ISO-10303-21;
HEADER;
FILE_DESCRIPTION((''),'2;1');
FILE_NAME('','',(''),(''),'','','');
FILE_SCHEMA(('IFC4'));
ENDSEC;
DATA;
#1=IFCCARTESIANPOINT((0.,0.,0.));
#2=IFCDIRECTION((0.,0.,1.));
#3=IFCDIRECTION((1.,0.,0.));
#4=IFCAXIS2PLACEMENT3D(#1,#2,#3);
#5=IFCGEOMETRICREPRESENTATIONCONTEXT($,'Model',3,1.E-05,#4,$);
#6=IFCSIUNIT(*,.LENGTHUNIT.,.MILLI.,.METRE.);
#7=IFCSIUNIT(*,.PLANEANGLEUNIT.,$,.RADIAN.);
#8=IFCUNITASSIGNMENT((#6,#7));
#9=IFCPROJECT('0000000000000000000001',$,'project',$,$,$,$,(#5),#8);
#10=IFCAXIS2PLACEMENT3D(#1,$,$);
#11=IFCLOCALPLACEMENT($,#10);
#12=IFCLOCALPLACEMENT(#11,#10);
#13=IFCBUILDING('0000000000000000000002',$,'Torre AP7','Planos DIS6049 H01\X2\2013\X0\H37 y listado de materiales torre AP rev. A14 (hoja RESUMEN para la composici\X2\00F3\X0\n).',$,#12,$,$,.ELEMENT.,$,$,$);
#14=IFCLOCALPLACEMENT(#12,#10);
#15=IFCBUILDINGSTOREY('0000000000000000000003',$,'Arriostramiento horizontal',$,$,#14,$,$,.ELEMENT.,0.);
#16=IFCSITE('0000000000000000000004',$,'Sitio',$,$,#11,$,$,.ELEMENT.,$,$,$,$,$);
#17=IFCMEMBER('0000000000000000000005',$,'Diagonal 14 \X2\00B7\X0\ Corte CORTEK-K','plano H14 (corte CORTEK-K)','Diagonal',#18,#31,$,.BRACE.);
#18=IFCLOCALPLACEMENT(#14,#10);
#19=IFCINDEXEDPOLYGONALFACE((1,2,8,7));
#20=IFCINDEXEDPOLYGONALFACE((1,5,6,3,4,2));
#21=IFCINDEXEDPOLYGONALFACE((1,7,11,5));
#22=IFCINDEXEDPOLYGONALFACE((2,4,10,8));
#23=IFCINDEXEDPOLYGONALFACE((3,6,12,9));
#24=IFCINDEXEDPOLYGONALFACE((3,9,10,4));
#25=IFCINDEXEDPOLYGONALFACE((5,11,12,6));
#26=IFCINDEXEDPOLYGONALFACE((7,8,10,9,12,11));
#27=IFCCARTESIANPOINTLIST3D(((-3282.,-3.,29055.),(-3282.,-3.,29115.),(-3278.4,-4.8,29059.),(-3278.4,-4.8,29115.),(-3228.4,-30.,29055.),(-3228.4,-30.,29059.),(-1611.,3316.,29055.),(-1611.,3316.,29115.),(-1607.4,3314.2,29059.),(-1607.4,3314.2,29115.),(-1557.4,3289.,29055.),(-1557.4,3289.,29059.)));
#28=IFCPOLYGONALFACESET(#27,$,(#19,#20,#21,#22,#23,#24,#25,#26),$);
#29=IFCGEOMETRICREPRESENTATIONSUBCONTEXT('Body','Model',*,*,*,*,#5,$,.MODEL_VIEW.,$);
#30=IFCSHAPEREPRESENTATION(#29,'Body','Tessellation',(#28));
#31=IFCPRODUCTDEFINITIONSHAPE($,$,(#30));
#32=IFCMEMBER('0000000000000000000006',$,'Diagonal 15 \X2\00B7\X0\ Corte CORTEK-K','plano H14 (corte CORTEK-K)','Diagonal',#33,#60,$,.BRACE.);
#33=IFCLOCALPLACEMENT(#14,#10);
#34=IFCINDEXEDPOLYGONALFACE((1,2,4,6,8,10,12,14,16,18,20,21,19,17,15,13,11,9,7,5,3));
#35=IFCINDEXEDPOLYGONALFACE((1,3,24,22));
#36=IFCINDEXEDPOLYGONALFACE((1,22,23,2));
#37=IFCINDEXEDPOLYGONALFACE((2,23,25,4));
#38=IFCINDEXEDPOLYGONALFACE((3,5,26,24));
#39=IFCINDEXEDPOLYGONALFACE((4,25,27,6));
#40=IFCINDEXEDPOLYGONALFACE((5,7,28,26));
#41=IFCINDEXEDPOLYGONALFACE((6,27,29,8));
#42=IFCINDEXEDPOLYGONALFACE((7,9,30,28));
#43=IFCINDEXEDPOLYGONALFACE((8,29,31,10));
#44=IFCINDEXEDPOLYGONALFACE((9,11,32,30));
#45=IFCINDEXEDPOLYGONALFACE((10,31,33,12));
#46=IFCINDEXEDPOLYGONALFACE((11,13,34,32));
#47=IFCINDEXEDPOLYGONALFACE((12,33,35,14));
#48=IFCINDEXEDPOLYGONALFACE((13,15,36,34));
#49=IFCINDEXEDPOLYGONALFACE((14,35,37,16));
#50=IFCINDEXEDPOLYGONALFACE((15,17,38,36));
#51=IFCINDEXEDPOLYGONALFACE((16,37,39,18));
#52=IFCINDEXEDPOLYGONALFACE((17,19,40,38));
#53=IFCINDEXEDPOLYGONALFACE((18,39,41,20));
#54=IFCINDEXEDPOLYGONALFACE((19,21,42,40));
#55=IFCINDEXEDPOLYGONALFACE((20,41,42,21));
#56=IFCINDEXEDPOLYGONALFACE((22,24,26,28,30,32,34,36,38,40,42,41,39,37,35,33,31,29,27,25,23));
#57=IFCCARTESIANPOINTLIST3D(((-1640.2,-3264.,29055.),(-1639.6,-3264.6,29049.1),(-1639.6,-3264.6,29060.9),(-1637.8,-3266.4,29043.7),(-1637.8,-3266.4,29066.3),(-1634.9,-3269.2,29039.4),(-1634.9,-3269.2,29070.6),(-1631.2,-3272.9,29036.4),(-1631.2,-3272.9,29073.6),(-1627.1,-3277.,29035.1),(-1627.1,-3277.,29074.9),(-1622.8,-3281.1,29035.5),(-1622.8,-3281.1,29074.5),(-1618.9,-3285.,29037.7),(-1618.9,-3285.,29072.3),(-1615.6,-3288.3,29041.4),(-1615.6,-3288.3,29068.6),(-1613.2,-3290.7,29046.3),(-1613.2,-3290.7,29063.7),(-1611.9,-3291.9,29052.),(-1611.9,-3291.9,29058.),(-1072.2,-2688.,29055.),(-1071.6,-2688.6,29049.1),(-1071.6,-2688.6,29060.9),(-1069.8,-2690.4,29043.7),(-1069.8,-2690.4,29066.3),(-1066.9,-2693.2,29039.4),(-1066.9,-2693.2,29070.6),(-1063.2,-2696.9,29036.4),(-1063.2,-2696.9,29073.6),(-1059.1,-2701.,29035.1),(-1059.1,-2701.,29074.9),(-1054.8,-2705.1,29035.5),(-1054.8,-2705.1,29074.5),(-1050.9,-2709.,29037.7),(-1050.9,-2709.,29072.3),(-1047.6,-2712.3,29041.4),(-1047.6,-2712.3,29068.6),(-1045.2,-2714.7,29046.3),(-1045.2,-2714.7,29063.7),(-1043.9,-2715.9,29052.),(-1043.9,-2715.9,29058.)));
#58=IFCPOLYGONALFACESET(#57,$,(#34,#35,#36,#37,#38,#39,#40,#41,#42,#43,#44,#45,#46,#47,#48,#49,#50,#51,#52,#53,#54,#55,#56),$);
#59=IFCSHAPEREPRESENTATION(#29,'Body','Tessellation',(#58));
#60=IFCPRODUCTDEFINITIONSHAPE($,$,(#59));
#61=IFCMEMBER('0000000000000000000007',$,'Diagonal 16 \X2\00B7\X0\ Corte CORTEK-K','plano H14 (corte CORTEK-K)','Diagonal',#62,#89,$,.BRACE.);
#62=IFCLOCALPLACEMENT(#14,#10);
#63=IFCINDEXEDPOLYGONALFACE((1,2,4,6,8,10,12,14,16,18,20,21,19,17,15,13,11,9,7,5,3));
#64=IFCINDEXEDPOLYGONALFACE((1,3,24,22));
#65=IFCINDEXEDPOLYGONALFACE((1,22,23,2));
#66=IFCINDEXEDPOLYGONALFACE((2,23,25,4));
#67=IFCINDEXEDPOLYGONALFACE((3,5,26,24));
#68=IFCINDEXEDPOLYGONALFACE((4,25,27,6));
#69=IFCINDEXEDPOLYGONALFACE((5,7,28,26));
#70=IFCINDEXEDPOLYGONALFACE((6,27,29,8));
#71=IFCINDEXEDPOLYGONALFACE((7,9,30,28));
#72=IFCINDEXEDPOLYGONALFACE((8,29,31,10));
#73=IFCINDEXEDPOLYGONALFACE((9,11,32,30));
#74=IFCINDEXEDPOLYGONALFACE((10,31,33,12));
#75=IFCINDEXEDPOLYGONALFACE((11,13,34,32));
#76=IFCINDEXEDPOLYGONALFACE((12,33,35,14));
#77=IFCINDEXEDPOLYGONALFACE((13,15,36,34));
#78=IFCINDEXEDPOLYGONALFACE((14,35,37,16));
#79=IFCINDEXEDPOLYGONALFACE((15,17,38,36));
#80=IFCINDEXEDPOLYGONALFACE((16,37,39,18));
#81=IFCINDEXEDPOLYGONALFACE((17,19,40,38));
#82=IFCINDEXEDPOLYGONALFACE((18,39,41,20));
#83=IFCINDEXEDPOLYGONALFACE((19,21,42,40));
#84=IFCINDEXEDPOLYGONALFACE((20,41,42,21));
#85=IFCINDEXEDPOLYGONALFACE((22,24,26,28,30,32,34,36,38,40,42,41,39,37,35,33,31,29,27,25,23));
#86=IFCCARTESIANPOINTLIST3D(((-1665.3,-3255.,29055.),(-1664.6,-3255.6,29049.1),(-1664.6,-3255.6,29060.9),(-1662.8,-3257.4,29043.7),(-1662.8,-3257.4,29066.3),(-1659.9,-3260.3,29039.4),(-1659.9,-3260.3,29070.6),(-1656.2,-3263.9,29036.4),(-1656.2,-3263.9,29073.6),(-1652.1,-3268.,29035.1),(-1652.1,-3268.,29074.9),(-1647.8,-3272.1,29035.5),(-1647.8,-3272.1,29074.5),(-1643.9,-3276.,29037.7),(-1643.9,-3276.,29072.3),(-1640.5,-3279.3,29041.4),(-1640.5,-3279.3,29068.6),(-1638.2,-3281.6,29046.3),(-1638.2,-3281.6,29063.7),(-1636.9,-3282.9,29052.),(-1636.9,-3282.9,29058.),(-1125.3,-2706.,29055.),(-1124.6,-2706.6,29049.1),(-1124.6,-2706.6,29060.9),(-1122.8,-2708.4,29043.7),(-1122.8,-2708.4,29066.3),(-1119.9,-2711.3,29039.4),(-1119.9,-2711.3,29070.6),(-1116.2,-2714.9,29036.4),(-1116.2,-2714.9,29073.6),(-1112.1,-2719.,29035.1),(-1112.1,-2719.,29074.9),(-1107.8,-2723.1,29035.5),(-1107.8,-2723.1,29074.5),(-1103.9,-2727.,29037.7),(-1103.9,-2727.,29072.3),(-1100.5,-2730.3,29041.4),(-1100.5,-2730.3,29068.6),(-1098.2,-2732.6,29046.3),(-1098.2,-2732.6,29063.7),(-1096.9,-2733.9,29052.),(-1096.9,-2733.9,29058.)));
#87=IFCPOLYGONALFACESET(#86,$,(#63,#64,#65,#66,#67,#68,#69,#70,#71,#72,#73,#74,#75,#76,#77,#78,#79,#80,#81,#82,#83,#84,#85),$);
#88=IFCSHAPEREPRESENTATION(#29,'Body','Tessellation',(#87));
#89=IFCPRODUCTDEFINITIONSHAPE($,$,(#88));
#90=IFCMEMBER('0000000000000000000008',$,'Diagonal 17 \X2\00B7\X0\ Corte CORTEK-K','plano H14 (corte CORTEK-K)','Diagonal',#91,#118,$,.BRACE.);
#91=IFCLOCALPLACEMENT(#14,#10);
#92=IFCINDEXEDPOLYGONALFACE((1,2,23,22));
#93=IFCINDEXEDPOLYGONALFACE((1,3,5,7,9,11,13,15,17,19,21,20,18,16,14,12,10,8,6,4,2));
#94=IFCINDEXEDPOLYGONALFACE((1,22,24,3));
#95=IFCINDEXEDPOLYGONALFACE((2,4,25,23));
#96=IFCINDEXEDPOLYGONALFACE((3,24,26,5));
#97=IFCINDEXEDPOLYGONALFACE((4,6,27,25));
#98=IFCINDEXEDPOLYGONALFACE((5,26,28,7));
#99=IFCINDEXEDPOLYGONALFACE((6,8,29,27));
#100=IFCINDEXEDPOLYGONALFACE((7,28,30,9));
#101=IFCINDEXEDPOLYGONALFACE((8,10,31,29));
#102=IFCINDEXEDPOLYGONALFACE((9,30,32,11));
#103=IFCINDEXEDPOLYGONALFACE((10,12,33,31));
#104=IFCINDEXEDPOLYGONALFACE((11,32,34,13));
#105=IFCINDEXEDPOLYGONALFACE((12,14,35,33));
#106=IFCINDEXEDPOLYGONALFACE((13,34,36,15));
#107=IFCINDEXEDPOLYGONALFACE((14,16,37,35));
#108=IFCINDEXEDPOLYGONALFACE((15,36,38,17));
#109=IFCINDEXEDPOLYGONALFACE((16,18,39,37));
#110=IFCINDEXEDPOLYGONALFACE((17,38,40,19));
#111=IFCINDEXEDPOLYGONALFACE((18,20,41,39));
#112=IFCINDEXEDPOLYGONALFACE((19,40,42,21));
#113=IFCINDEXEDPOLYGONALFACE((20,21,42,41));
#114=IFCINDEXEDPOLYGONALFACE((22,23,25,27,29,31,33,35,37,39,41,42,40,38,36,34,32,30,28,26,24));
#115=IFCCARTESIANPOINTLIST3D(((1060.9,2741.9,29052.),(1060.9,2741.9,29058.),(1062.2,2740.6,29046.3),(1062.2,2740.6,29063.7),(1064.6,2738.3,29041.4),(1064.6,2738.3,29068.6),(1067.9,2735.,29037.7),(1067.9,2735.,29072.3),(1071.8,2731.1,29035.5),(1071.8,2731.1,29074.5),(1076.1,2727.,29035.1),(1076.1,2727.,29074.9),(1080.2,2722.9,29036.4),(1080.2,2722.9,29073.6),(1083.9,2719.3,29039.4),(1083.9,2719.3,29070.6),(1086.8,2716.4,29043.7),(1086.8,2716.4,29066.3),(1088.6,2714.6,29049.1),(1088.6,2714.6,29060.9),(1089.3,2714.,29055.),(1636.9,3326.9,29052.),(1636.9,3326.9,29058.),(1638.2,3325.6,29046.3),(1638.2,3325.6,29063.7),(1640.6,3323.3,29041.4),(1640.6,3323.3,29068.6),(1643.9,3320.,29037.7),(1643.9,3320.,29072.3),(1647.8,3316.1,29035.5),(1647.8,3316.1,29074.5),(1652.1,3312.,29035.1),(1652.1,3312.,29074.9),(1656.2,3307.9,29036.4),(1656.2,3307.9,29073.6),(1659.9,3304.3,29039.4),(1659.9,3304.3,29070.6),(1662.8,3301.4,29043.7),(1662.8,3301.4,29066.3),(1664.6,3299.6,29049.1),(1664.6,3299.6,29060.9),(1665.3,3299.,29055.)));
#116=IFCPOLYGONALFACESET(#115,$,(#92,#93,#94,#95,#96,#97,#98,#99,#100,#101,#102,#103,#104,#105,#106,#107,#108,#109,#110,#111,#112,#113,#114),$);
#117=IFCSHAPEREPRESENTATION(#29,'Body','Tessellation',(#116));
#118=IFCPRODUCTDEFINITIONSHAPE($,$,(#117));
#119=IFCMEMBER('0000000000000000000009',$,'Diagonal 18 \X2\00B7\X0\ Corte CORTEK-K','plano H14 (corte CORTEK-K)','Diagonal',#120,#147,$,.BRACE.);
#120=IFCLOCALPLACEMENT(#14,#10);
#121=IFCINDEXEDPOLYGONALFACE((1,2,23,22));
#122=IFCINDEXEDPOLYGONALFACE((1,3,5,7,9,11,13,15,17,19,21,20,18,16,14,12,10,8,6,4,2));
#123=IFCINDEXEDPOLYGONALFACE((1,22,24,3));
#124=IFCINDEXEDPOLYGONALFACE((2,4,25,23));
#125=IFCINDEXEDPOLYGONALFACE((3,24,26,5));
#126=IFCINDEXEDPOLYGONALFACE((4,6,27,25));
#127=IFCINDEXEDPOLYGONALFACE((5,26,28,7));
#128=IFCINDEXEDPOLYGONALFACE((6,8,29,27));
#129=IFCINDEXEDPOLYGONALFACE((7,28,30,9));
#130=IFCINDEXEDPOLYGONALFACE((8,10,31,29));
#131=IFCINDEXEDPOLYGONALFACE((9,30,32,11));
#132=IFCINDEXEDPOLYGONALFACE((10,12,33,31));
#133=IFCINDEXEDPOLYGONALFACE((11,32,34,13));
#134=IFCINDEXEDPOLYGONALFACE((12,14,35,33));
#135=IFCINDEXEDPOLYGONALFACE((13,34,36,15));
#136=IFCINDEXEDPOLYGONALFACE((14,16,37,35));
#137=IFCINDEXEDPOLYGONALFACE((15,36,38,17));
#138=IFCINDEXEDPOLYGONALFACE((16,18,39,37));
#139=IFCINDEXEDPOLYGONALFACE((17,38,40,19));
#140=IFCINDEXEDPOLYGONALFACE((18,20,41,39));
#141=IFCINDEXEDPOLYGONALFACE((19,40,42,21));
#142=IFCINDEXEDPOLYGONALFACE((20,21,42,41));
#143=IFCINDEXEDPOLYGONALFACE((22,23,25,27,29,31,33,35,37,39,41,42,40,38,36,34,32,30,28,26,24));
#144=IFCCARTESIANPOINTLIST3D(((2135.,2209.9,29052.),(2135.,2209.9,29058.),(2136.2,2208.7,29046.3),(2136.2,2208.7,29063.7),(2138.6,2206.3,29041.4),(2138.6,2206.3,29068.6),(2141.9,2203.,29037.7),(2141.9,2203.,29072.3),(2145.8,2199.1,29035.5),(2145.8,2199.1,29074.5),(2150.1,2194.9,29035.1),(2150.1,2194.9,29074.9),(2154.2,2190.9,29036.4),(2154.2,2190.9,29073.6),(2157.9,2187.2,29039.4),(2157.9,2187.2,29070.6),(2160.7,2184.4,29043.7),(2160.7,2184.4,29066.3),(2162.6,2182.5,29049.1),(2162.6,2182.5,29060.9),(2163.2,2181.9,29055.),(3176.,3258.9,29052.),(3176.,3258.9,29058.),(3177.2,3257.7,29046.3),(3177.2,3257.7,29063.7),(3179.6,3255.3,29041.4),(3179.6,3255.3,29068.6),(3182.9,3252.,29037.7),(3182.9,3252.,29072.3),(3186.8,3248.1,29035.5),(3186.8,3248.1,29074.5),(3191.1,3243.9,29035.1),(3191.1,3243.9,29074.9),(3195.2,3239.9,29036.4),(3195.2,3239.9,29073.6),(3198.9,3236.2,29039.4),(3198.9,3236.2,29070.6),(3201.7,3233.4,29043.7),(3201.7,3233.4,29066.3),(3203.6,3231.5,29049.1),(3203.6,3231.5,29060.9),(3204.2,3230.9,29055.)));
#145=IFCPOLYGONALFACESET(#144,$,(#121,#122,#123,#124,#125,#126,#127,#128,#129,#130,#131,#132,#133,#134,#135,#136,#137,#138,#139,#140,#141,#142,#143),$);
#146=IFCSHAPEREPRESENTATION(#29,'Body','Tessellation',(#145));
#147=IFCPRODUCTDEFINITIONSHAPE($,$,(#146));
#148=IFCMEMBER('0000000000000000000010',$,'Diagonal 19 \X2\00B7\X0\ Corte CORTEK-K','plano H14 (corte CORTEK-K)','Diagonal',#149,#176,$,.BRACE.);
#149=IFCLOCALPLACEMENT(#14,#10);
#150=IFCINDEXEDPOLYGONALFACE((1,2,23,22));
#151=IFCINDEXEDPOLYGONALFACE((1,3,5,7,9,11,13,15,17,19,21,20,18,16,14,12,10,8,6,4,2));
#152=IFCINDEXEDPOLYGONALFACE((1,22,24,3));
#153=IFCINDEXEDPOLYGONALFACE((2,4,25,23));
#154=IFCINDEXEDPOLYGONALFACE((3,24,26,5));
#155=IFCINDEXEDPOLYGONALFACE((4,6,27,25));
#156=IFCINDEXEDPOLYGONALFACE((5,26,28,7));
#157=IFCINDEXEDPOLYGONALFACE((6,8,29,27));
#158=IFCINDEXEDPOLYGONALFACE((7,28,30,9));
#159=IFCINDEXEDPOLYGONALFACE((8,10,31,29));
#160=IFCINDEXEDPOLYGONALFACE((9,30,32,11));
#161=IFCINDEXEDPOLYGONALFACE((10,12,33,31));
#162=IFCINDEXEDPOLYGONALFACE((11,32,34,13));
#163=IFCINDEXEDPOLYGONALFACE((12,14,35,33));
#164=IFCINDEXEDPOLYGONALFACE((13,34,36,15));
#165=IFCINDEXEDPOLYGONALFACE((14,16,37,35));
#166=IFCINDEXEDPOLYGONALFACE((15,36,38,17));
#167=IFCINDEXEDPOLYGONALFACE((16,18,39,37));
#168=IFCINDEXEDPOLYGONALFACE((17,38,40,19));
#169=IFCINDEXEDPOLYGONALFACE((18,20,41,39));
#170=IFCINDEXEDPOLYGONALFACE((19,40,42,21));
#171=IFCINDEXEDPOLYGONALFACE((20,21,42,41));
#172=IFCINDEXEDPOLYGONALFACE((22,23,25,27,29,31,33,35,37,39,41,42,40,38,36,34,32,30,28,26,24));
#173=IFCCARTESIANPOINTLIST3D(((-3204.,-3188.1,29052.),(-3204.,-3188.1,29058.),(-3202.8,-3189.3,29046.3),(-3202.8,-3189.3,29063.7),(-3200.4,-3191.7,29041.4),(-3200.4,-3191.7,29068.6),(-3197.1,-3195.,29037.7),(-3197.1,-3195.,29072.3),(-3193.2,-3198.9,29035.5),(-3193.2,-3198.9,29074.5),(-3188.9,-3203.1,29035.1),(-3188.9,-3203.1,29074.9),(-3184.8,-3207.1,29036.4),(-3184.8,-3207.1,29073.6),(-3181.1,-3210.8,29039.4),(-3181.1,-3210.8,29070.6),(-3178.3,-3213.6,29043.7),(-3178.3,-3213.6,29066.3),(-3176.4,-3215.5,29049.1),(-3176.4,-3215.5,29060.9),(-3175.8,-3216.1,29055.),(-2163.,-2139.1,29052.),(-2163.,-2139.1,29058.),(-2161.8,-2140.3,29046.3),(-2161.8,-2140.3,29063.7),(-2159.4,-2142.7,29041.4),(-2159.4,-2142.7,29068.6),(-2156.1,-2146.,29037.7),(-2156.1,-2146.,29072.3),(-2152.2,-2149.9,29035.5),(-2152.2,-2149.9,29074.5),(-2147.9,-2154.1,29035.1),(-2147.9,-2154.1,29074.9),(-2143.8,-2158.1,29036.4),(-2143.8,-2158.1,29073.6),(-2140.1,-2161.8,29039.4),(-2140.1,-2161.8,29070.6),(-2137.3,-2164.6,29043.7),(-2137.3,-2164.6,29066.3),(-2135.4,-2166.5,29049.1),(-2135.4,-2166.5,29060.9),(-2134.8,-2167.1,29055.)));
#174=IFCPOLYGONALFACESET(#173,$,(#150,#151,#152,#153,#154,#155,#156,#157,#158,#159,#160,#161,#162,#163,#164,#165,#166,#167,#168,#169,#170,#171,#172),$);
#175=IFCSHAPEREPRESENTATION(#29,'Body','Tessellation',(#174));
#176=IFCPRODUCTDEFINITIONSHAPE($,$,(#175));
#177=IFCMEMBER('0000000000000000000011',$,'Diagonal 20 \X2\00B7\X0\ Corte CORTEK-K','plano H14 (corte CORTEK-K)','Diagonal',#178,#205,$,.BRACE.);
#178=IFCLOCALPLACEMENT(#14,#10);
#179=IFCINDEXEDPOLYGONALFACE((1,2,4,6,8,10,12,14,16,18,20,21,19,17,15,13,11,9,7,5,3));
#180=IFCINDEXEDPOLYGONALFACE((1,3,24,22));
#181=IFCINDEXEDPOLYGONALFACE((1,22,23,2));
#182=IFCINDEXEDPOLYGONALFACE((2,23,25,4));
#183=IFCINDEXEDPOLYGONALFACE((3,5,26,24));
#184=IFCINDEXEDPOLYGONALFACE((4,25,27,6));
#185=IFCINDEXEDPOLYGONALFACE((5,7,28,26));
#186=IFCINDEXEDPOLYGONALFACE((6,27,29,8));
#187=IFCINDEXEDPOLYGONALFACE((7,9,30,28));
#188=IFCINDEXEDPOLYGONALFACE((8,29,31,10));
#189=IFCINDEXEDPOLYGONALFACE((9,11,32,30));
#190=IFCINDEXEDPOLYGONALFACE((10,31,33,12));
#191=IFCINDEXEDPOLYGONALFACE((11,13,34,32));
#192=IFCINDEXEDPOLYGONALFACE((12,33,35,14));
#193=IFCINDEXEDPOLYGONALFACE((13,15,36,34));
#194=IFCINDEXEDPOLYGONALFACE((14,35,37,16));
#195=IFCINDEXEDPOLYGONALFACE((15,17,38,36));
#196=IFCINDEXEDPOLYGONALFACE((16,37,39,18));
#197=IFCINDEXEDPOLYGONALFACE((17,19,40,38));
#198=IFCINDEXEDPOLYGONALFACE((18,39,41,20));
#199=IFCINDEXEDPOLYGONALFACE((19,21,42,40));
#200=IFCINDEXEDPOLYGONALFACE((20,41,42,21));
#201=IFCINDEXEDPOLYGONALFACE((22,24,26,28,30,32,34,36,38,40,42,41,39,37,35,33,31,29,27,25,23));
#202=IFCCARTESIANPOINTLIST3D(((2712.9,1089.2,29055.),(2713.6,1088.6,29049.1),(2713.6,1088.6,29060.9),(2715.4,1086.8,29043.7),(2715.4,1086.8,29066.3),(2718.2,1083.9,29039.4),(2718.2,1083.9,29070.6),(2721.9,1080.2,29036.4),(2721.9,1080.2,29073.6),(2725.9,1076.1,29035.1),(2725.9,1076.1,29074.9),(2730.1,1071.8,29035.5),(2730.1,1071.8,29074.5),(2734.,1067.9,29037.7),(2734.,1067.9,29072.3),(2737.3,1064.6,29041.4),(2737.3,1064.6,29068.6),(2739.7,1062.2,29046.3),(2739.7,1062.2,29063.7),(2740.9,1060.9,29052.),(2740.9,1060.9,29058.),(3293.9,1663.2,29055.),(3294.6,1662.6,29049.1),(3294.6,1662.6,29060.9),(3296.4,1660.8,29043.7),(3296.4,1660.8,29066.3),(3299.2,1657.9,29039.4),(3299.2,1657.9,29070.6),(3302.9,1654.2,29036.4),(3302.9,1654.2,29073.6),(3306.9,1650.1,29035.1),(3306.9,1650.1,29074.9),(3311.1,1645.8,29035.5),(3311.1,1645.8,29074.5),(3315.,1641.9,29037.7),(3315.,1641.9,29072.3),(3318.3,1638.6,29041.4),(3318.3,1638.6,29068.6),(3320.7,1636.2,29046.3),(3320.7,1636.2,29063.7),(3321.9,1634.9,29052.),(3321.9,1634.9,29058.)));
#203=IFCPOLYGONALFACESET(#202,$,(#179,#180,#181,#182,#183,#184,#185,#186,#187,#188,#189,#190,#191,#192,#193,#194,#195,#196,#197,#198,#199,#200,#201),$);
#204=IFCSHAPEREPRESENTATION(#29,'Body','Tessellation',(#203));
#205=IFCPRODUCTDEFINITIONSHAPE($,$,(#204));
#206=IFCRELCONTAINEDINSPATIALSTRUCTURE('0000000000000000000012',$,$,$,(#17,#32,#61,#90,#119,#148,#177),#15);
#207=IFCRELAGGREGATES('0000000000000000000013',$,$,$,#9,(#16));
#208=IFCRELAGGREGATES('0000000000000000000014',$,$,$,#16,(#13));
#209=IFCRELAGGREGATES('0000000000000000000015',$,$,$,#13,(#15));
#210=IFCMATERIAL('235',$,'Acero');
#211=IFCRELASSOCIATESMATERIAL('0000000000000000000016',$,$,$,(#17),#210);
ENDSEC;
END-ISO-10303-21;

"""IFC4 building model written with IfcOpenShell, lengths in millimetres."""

from ifc_helpers import new_model, si_unit, frame, frame_2d, origin, origin_with_axes, place, context, subcontext, project, spatial, circle, l_section, extrude, material, element, save


model = new_model("IFC4")

# Units and contexts
model_context = context("Model", 3, precision=1e-05, world=origin_with_axes())
body_context = subcontext(model_context, "Body", "Model", "MODEL_VIEW")
ifc_project = project(units=[si_unit("LENGTHUNIT", "METRE", prefix="MILLI"), si_unit("PLANEANGLEUNIT", "RADIAN")], contexts=[model_context])

# Site, building, storey
site_placement = place(None, origin())
site = spatial("IfcSite", under=ifc_project, at=site_placement, Name="Sitio", CompositionType="ELEMENT")
building_placement = place(site_placement, origin())
building = spatial("IfcBuilding", under=site, at=building_placement, Name="Torre AP7", Description="Planos DIS6049 H01–H37 y listado de materiales torre AP rev. A14 (hoja RESUMEN para la composición).", CompositionType="ELEMENT")
storey_placement = place(building_placement, origin())
storey = spatial("IfcBuildingStorey", under=building, at=storey_placement, Name="Arriostramiento horizontal", CompositionType="ELEMENT", Elevation=0.0)

# Members
ifc_material = material(Name="235", Category="Acero")
member_1_placement = place(storey_placement, frame((-1611.0, 3316.0, 29055.0), z_axis=(-0.449688, -0.893186, 0.0), x_axis=(0.893186, -0.449688, 0.0)))
element("IfcMember", 1, at=member_1_placement, inside=storey, material=ifc_material, Name="Diagonal 14 · Corte CORTEK-K", Description="plano H14 (corte CORTEK-K)", ObjectType="Diagonal", PredefinedType="BRACE", context=body_context, shape_type="SweptSolid", body=[
    extrude(l_section(Depth=60.0, Width=60.0, Thickness=4.0, at=frame_2d((30.0, 30.0))), None, (0.0, 0.0, 1.0), 3715.9),
])
member_2_placement = place(storey_placement, frame((-1058.0, -2702.0, 29055.0), z_axis=(-0.702145, -0.712034, 0.0), x_axis=(-0.712034, 0.702145, 0.0)))
element("IfcMember", 2, at=member_2_placement, inside=storey, Name="Diagonal 15 · Corte CORTEK-K", Description="plano H14 (corte CORTEK-K)", ObjectType="Diagonal", PredefinedType="BRACE", context=body_context, shape_type="SweptSolid", body=[
    extrude(circle(Radius=20.0), None, (0.0, 0.0, 1.0), 808.9),
])
member_3_placement = place(storey_placement, frame((-1111.0, -2720.0, 29055.0), z_axis=(-0.701239, -0.712926, 0.0), x_axis=(-0.712926, 0.701239, 0.0)))
element("IfcMember", 3, at=member_3_placement, inside=storey, Name="Diagonal 16 · Corte CORTEK-K", Description="plano H14 (corte CORTEK-K)", ObjectType="Diagonal", PredefinedType="BRACE", context=body_context, shape_type="SweptSolid", body=[
    extrude(circle(Radius=20.0), None, (0.0, 0.0, 1.0), 770.1),
])
member_4_placement = place(storey_placement, frame((1651.0, 3313.0, 29055.0), z_axis=(-0.701604, -0.712567, 0.0), x_axis=(0.712567, -0.701604, 0.0)))
element("IfcMember", 4, at=member_4_placement, inside=storey, Name="Diagonal 17 · Corte CORTEK-K", Description="plano H14 (corte CORTEK-K)", ObjectType="Diagonal", PredefinedType="BRACE", context=body_context, shape_type="SweptSolid", body=[
    extrude(circle(Radius=20.0), None, (0.0, 0.0, 1.0), 821.0),
])
for number, where, z_axis, x_axis, name in (
    (5, (3190.0, 3245.0, 29055.0), (-0.704395, -0.709808, 0.0), (0.709808, -0.704395, 0.0), "Diagonal 18 · Corte CORTEK-K"),
    (6, (-2149.0, -2153.0, 29055.0), (-0.704395, -0.709808, 0.0), (0.709808, -0.704395, 0.0), "Diagonal 19 · Corte CORTEK-K"),
):
    element("IfcMember", number, at=place(storey_placement, frame(where, z_axis=z_axis, x_axis=x_axis)), inside=storey, Name=name, Description="plano H14 (corte CORTEK-K)", ObjectType="Diagonal", PredefinedType="BRACE", context=body_context, shape_type="SweptSolid", body=[
        extrude(circle(Radius=20.0), None, (0.0, 0.0, 1.0), 1477.9),
    ])
for number, where, z_axis, x_axis, name in (
    (7, (3308.0, 1649.0, 29055.0), (-0.711379, -0.702808, 0.0), (-0.702808, 0.711379, 0.0), "Diagonal 20 · Corte CORTEK-K"),
):
    element("IfcMember", number, at=place(storey_placement, frame(where, z_axis=z_axis, x_axis=x_axis)), inside=storey, Name=name, Description="plano H14 (corte CORTEK-K)", ObjectType="Diagonal", PredefinedType="BRACE", context=body_context, shape_type="SweptSolid", body=[
        extrude(circle(Radius=20.0), None, (0.0, 0.0, 1.0), 816.7),
    ])

save(model, "model.ifc")
